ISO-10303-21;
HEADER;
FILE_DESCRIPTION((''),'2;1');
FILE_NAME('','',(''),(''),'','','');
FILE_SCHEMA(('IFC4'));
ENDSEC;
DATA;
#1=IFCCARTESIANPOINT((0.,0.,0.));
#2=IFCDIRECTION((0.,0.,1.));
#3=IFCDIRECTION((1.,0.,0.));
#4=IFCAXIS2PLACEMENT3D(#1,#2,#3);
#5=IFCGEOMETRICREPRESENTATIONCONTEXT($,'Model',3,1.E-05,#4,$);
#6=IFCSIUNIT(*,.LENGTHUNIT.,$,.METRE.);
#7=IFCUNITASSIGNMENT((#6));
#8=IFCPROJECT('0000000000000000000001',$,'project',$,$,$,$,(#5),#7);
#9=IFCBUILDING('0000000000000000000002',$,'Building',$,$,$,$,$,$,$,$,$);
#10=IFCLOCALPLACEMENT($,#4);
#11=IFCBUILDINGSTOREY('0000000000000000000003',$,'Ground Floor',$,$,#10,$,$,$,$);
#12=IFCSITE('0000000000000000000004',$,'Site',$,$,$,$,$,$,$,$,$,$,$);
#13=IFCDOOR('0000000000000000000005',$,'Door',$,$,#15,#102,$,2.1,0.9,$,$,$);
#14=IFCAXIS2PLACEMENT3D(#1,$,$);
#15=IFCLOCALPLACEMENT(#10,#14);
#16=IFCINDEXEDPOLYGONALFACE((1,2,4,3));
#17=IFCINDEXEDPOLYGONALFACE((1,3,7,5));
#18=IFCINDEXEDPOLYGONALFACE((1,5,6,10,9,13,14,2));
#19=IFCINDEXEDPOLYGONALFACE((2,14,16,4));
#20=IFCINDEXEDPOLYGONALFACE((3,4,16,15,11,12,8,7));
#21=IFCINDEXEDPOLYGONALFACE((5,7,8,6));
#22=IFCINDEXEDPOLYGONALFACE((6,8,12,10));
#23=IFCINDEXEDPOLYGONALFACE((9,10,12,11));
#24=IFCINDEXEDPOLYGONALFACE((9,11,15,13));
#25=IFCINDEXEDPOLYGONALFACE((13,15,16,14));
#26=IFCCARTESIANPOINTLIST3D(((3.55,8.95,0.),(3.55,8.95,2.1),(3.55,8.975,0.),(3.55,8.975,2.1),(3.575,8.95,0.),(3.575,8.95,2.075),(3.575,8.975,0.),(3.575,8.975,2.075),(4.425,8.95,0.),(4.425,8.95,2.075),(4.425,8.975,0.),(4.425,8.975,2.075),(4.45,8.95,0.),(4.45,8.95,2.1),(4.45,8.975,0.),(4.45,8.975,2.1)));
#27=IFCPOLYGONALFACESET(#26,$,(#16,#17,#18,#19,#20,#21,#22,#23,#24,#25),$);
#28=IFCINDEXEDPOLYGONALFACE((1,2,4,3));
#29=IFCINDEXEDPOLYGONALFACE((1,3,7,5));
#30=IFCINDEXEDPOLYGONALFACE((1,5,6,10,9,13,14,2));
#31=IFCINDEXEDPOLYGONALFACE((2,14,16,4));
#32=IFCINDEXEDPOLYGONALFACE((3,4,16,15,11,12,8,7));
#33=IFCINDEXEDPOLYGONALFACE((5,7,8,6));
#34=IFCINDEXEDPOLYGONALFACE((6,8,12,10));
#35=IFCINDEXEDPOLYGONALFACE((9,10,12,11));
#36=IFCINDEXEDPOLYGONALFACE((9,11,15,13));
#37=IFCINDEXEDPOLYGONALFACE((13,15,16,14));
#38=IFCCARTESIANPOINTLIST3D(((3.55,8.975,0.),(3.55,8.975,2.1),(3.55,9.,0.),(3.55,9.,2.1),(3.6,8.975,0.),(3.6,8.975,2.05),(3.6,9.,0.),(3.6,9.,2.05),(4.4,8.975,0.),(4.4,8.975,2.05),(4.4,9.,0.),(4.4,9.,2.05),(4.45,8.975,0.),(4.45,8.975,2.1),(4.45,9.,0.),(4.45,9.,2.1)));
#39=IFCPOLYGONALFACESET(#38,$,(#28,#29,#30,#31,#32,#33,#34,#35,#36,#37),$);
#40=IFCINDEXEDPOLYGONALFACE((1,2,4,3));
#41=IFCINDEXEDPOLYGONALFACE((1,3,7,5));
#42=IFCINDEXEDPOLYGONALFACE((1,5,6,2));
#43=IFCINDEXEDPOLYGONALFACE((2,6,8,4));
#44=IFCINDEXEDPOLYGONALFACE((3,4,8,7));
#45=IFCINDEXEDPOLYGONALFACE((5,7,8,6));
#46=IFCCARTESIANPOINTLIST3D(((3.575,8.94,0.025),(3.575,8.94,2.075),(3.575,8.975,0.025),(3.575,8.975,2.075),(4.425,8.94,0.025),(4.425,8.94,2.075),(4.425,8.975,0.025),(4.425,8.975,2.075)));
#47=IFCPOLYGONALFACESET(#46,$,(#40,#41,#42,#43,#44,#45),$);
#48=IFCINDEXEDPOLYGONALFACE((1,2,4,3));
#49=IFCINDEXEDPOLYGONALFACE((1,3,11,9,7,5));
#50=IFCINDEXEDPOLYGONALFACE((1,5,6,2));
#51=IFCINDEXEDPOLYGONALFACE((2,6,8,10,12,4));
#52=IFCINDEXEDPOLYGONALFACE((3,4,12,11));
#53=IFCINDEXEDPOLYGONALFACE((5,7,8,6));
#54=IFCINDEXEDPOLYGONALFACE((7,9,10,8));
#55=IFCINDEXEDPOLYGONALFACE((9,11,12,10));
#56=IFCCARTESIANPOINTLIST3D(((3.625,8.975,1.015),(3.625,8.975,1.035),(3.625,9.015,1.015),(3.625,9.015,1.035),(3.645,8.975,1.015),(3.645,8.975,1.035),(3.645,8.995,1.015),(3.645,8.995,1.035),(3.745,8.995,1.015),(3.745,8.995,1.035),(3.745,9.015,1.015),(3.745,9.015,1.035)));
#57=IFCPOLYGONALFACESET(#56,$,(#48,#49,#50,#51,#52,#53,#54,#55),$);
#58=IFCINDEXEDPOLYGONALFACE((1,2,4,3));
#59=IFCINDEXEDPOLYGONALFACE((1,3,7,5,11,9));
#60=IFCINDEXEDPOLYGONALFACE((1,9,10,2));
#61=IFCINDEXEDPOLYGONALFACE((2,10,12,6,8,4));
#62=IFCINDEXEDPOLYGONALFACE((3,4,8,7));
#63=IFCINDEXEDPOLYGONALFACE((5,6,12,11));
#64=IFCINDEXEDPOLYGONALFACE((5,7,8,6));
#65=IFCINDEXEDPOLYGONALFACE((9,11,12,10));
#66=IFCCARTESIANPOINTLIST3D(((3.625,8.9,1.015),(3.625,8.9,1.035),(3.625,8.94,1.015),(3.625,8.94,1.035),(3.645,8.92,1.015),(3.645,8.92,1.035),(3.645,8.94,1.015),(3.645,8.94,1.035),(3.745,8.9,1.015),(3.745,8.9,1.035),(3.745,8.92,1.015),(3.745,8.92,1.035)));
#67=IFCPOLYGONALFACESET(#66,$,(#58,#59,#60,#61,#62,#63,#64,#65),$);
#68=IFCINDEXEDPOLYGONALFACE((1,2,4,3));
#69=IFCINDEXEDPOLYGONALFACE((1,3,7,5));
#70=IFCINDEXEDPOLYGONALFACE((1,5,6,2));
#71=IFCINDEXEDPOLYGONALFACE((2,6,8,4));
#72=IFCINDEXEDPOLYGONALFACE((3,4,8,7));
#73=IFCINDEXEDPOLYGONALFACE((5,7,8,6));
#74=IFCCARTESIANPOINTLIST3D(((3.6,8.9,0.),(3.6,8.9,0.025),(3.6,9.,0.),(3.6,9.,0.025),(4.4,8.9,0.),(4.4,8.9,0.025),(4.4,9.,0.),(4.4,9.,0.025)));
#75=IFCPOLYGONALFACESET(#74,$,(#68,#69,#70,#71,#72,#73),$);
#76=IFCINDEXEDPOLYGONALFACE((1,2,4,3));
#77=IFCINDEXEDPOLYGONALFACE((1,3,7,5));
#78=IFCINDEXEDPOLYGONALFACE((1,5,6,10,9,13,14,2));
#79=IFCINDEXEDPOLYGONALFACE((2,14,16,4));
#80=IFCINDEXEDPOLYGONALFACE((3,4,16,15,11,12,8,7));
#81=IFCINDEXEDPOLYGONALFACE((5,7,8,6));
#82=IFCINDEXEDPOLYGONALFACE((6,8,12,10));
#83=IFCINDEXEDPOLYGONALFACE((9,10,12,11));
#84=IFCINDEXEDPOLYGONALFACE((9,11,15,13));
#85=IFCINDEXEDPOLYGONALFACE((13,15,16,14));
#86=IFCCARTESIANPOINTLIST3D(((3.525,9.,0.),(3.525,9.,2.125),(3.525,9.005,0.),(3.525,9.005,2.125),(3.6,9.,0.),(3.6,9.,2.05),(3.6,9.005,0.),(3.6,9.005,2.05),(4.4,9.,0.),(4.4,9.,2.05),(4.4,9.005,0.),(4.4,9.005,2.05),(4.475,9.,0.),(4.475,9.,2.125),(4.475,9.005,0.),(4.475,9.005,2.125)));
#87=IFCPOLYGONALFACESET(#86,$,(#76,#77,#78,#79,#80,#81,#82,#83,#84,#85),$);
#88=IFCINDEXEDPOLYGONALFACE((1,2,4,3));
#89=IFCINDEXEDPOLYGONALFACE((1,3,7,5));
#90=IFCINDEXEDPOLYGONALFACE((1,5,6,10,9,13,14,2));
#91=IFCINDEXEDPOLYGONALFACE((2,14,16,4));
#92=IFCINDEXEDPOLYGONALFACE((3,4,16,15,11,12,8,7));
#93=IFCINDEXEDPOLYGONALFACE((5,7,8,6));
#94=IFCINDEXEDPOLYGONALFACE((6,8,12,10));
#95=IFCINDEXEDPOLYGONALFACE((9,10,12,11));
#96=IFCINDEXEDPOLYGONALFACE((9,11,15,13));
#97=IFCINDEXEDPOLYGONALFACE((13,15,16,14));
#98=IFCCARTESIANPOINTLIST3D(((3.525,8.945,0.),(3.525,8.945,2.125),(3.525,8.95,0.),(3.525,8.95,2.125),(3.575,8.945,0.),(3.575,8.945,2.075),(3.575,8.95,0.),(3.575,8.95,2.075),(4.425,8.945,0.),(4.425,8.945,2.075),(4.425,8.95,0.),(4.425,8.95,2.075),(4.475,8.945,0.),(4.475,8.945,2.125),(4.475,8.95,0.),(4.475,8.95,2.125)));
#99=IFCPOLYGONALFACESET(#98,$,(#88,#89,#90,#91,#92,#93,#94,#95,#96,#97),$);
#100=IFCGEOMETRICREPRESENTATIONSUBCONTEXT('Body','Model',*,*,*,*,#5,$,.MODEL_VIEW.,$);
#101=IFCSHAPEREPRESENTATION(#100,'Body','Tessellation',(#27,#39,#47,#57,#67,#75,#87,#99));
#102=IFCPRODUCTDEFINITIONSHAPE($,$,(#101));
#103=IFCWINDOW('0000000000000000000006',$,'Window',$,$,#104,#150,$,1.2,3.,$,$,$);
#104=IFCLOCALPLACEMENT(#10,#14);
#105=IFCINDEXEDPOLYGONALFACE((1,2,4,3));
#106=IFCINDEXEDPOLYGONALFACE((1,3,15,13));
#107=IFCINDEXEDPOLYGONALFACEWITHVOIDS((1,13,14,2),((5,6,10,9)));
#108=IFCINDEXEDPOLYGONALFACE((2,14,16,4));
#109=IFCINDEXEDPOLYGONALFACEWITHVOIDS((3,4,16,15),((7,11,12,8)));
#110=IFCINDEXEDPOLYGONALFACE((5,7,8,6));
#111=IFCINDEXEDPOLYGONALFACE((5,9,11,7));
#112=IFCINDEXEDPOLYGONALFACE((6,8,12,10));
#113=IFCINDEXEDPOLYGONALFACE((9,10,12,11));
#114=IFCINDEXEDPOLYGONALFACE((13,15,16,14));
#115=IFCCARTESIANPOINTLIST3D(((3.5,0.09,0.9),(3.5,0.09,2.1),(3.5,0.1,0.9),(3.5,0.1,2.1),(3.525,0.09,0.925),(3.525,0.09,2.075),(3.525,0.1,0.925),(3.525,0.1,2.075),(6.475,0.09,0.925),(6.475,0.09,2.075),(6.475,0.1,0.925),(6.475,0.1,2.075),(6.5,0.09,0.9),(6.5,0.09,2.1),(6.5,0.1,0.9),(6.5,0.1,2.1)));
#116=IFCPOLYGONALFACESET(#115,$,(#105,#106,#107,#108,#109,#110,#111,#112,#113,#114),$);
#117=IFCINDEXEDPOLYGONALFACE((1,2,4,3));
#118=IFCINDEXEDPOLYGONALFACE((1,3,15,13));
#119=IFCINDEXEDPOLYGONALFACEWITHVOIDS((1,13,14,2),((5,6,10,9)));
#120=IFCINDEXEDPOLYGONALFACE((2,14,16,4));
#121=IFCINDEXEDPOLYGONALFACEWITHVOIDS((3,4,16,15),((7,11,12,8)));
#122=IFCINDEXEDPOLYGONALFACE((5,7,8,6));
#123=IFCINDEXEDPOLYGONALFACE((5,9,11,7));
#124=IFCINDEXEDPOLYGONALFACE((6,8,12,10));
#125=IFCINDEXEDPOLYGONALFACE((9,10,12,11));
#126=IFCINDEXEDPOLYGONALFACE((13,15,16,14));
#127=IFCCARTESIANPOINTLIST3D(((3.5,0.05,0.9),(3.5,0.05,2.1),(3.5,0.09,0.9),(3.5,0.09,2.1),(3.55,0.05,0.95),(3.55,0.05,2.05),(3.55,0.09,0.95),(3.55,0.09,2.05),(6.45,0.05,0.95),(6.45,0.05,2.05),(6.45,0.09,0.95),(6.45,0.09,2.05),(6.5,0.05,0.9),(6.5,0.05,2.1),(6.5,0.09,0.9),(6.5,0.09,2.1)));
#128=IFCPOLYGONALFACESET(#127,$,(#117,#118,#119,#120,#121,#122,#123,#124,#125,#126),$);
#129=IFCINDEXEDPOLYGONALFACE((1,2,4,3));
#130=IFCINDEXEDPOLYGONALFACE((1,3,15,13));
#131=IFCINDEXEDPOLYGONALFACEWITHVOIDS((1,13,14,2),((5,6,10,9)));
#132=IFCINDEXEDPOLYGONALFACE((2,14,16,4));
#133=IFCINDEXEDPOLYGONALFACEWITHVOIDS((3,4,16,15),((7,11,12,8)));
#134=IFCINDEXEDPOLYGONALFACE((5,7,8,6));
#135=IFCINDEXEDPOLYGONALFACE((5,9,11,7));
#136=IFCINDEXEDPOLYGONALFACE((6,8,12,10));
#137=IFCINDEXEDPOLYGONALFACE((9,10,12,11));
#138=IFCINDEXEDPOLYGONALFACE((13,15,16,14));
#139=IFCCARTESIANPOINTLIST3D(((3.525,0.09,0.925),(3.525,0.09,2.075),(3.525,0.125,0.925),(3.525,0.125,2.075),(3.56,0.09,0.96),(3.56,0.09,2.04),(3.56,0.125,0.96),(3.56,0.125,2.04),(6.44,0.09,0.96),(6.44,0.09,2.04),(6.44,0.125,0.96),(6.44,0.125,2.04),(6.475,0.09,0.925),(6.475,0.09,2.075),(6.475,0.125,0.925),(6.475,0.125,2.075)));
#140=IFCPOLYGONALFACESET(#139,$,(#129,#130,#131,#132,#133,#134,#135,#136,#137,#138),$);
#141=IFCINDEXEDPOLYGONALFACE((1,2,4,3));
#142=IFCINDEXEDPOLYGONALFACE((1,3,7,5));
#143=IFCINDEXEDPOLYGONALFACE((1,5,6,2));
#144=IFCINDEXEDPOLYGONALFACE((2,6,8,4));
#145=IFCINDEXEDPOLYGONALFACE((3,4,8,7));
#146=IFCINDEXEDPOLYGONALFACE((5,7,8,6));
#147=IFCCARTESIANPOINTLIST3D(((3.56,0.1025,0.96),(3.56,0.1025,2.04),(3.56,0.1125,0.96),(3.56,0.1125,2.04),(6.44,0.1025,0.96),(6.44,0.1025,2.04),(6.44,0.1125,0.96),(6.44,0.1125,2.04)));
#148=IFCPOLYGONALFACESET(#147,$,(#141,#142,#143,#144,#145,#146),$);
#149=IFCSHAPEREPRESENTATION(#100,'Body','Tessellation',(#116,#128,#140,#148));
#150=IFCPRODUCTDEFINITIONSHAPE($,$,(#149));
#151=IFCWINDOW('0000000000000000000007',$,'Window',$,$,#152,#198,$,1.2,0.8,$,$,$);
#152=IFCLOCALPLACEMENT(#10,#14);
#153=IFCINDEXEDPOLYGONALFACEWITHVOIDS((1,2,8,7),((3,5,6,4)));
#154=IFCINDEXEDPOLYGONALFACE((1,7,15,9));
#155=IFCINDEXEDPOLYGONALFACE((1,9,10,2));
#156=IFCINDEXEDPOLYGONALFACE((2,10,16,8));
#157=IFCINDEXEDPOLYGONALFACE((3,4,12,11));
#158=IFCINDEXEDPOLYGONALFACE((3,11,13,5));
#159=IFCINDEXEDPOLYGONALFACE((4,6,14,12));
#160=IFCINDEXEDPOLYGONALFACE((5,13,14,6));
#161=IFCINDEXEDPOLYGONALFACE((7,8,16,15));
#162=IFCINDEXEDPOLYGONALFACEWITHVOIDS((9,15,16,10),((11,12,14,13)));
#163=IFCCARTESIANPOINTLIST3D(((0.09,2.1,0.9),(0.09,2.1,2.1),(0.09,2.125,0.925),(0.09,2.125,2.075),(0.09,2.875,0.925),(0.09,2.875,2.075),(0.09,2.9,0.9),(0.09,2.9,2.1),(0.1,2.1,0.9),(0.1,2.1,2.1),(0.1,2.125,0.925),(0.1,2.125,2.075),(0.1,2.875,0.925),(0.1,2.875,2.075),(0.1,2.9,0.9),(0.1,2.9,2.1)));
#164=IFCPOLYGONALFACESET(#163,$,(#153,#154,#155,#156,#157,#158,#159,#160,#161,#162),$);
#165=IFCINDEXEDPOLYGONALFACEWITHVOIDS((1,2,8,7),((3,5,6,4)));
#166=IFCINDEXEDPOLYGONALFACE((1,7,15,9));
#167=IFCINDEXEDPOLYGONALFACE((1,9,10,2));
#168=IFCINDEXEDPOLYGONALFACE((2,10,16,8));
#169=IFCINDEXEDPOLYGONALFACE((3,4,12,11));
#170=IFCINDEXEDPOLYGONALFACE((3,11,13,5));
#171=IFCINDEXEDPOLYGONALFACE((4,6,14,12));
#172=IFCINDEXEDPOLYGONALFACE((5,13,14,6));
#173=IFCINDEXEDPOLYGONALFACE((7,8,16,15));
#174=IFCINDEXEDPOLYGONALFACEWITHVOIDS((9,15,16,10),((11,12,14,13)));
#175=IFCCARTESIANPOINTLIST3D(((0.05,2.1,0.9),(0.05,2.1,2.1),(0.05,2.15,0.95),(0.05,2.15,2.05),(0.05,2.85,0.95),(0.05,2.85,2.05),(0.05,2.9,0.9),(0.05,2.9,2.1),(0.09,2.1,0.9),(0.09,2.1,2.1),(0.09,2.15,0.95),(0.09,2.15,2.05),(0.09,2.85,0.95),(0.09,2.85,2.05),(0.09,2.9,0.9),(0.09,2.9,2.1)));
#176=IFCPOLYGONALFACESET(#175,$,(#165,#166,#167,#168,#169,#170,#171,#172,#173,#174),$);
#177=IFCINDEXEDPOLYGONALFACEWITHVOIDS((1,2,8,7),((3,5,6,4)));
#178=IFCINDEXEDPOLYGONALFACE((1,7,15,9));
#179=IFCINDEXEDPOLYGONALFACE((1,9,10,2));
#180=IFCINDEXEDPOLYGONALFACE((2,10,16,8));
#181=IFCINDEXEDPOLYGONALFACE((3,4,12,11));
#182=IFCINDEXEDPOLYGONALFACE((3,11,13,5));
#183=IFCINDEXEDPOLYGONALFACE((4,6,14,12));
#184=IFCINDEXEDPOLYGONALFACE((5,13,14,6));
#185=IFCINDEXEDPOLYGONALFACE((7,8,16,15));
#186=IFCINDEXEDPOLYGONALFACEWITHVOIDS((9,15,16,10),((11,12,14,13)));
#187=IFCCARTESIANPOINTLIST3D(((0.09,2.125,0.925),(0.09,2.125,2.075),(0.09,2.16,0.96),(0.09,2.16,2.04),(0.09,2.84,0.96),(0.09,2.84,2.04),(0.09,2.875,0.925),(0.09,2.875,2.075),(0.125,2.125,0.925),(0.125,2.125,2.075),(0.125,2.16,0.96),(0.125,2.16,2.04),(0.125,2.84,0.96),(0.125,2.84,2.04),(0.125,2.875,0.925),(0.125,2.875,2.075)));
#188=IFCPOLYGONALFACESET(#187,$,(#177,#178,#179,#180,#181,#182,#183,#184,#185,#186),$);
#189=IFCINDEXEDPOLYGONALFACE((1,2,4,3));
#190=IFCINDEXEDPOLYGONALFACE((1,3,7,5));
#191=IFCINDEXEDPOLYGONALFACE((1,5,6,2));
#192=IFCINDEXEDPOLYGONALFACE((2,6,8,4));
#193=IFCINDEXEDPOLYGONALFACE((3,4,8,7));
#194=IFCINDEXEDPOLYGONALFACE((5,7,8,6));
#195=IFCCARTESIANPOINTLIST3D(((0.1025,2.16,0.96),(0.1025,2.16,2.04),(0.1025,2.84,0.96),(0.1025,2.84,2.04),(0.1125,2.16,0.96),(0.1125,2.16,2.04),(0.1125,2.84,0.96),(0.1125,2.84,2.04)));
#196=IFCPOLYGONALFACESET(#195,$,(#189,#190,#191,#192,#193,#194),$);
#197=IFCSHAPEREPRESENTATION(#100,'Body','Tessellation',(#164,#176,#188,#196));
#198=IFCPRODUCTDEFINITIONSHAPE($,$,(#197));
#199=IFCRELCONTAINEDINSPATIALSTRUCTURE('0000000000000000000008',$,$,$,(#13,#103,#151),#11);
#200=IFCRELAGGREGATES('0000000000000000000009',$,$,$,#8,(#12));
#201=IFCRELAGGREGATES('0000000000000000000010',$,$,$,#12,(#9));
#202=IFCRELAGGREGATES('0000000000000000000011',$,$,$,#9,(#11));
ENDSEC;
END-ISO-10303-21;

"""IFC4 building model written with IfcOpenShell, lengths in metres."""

from ifc_helpers import new_model, si_unit, frame, origin_with_axes, place, context, subcontext, project, spatial, line, indexed_curve, outline, extrude, element, save


model = new_model("IFC4")

# Units and contexts
model_context = context("Model", 3, precision=1e-05, world=origin_with_axes())
body_context = subcontext(model_context, "Body", "Model", "MODEL_VIEW")
ifc_project = project(units=[si_unit("LENGTHUNIT", "METRE")], contexts=[model_context])

# Site, building, storey
site = spatial("IfcSite", under=ifc_project, Name="Site")
building = spatial("IfcBuilding", under=site, Name="Building")
storey_placement = place(None, origin_with_axes())
storey = spatial("IfcBuildingStorey", under=building, at=storey_placement, Name="Ground Floor")

# Door
door_1_placement = place(storey_placement, frame((4.45, 9.0, 0.0), z_axis=(0.0, 0.0, 1.0), x_axis=(-1.0, 0.0, 0.0)))
element("IfcDoor", 1, at=door_1_placement, inside=storey, Name="Door", OverallHeight=2.1, OverallWidth=0.9, context=body_context, shape_type="SweptSolid", body=[
    extrude(outline(indexed_curve([(0.0, 0.0), (0.0, 2.1), (0.9, 2.1), (0.9, 0.0), (0.875, 0.0), (0.875, 2.075), (0.025, 2.075), (0.025, 0.0)], segments=[line(1, 2, 3, 4, 5, 6, 7, 8, 1)])), frame((0.0, 0.025, 0.0), z_axis=(0.0, -1.0, 0.0), x_axis=(1.0, 0.0, 0.0)), (0.0, 0.0, -1.0), 0.025),
    extrude(outline(indexed_curve([(0.0, 0.0), (0.0, 2.1), (0.9, 2.1), (0.9, 0.0), (0.85, 0.0), (0.85, 2.05), (0.05, 2.05), (0.05, 0.0)], segments=[line(1, 2, 3, 4, 5, 6, 7, 8, 1)])), frame((0.0, 0.0, 0.0), z_axis=(0.0, -1.0, 0.0), x_axis=(1.0, 0.0, 0.0)), (0.0, 0.0, -1.0), 0.025),
    extrude(outline(indexed_curve([(0.0, 0.0), (0.85, 0.0), (0.85, 0.035), (0.0, 0.035)], segments=[line(1, 2, 3, 4, 1)])), frame((0.025, 0.025, 0.025), z_axis=(0.0, 0.0, 1.0), x_axis=(1.0, 0.0, 0.0)), (0.0, 0.0, 1.0), 2.05),
    extrude(outline(indexed_curve([(0.0, 0.0), (0.0, -0.04), (-0.12, -0.04), (-0.12, -0.02), (-0.02, -0.02), (-0.02, 0.0)], segments=[line(1, 2, 3, 4, 5, 6, 1)])), frame((0.825, 0.025, 1.015), z_axis=(0.0, 0.0, 1.0), x_axis=(1.0, 0.0, 0.0)), (0.0, 0.0, 1.0), 0.02),
    extrude(outline(indexed_curve([(0.0, 0.0), (0.0, 0.04), (-0.12, 0.04), (-0.12, 0.02), (-0.02, 0.02), (-0.02, 0.0)], segments=[line(1, 2, 3, 4, 5, 6, 1)])), frame((0.825, 0.06, 1.015), z_axis=(0.0, 0.0, 1.0), x_axis=(1.0, 0.0, 0.0)), (0.0, 0.0, 1.0), 0.02),
    extrude(outline(indexed_curve([(0.0, 0.0), (0.8, 0.0), (0.8, 0.1), (0.0, 0.1)], segments=[line(1, 2, 3, 4, 1)])), frame((0.05, 0.0, 0.0), z_axis=(0.0, 0.0, 1.0), x_axis=(1.0, 0.0, 0.0)), (0.0, 0.0, 1.0), 0.025),
    extrude(outline(indexed_curve([(0.0, 0.0), (0.0, 2.125), (0.95, 2.125), (0.95, 0.0), (0.875, 0.0), (0.875, 2.05), (0.075, 2.05), (0.075, 0.0)], segments=[line(1, 2, 3, 4, 5, 6, 7, 8, 1)])), frame((-0.025, -0.005, 0.0), z_axis=(0.0, -1.0, 0.0), x_axis=(1.0, 0.0, 0.0)), (0.0, 0.0, -1.0), 0.005),
    extrude(outline(indexed_curve([(0.0, 0.0), (0.0, 2.125), (0.95, 2.125), (0.95, 0.0), (0.9, 0.0), (0.9, 2.075), (0.05, 2.075), (0.05, 0.0)], segments=[line(1, 2, 3, 4, 5, 6, 7, 8, 1)])), frame((-0.025, 0.05, 0.0), z_axis=(0.0, -1.0, 0.0), x_axis=(1.0, 0.0, 0.0)), (0.0, 0.0, -1.0), 0.005),
])

# Windows
window_1_placement = place(storey_placement, frame((3.5, 0.0, 0.9), z_axis=(0.0, 0.0, 1.0), x_axis=(1.0, 0.0, 0.0)))
element("IfcWindow", 2, at=window_1_placement, inside=storey, Name="Window", OverallHeight=1.2, OverallWidth=3.0, context=body_context, shape_type="SweptSolid", body=[
    extrude(outline(indexed_curve([(0.0, 0.0), (3.0, 0.0), (3.0, 1.2), (0.0, 1.2)], segments=[line(1, 2, 3, 4, 1)]), holes=[indexed_curve([(0.025, 0.025), (2.975, 0.025), (2.975, 1.175), (0.025, 1.175)], segments=[line(1, 2, 3, 4, 1)])]), frame((0.0, 0.09, 0.0), z_axis=(0.0, -1.0, 0.0), x_axis=(1.0, 0.0, 0.0)), (0.0, 0.0, -1.0), 0.01),
    extrude(outline(indexed_curve([(0.0, 0.0), (3.0, 0.0), (3.0, 1.2), (0.0, 1.2)], segments=[line(1, 2, 3, 4, 1)]), holes=[indexed_curve([(0.05, 0.05), (2.95, 0.05), (2.95, 1.15), (0.05, 1.15)], segments=[line(1, 2, 3, 4, 1)])]), frame((0.0, 0.05, 0.0), z_axis=(0.0, -1.0, 0.0), x_axis=(1.0, 0.0, 0.0)), (0.0, 0.0, -1.0), 0.04),
    extrude(outline(indexed_curve([(0.0, 0.0), (2.95, 0.0), (2.95, 1.15), (0.0, 1.15)], segments=[line(1, 2, 3, 4, 1)]), holes=[indexed_curve([(0.035, 0.035), (2.915, 0.035), (2.915, 1.115), (0.035, 1.115)], segments=[line(1, 2, 3, 4, 1)])]), frame((0.025, 0.09, 0.025), z_axis=(0.0, -1.0, 0.0), x_axis=(1.0, 0.0, 0.0)), (0.0, 0.0, -1.0), 0.035),
    extrude(outline(indexed_curve([(0.035, 0.035), (2.915, 0.035), (2.915, 1.115), (0.035, 1.115)], segments=[line(1, 2, 3, 4, 1)])), frame((0.025, 0.1025, 0.025), z_axis=(0.0, -1.0, 0.0), x_axis=(1.0, 0.0, 0.0)), (0.0, 0.0, -1.0), 0.01),
])
window_2_placement = place(storey_placement, frame((0.0, 2.9, 0.9), z_axis=(0.0, 0.0, 1.0), x_axis=(0.0, -1.0, 0.0)))
element("IfcWindow", 3, at=window_2_placement, inside=storey, Name="Window", OverallHeight=1.2, OverallWidth=0.8, context=body_context, shape_type="SweptSolid", body=[
    extrude(outline(indexed_curve([(0.0, 0.0), (0.8, 0.0), (0.8, 1.2), (0.0, 1.2)], segments=[line(1, 2, 3, 4, 1)]), holes=[indexed_curve([(0.025, 0.025), (0.775, 0.025), (0.775, 1.175), (0.025, 1.175)], segments=[line(1, 2, 3, 4, 1)])]), frame((0.0, 0.09, 0.0), z_axis=(0.0, -1.0, 0.0), x_axis=(1.0, 0.0, 0.0)), (0.0, 0.0, -1.0), 0.01),
    extrude(outline(indexed_curve([(0.0, 0.0), (0.8, 0.0), (0.8, 1.2), (0.0, 1.2)], segments=[line(1, 2, 3, 4, 1)]), holes=[indexed_curve([(0.05, 0.05), (0.75, 0.05), (0.75, 1.15), (0.05, 1.15)], segments=[line(1, 2, 3, 4, 1)])]), frame((0.0, 0.05, 0.0), z_axis=(0.0, -1.0, 0.0), x_axis=(1.0, 0.0, 0.0)), (0.0, 0.0, -1.0), 0.04),
    extrude(outline(indexed_curve([(0.0, 0.0), (0.75, 0.0), (0.75, 1.15), (0.0, 1.15)], segments=[line(1, 2, 3, 4, 1)]), holes=[indexed_curve([(0.035, 0.035), (0.715, 0.035), (0.715, 1.115), (0.035, 1.115)], segments=[line(1, 2, 3, 4, 1)])]), frame((0.025, 0.09, 0.025), z_axis=(0.0, -1.0, 0.0), x_axis=(1.0, 0.0, 0.0)), (0.0, 0.0, -1.0), 0.035),
    extrude(outline(indexed_curve([(0.035, 0.035), (0.715, 0.035), (0.715, 1.115), (0.035, 1.115)], segments=[line(1, 2, 3, 4, 1)])), frame((0.025, 0.1025, 0.025), z_axis=(0.0, -1.0, 0.0), x_axis=(1.0, 0.0, 0.0)), (0.0, 0.0, -1.0), 0.01),
])

save(model, "model.ifc")
